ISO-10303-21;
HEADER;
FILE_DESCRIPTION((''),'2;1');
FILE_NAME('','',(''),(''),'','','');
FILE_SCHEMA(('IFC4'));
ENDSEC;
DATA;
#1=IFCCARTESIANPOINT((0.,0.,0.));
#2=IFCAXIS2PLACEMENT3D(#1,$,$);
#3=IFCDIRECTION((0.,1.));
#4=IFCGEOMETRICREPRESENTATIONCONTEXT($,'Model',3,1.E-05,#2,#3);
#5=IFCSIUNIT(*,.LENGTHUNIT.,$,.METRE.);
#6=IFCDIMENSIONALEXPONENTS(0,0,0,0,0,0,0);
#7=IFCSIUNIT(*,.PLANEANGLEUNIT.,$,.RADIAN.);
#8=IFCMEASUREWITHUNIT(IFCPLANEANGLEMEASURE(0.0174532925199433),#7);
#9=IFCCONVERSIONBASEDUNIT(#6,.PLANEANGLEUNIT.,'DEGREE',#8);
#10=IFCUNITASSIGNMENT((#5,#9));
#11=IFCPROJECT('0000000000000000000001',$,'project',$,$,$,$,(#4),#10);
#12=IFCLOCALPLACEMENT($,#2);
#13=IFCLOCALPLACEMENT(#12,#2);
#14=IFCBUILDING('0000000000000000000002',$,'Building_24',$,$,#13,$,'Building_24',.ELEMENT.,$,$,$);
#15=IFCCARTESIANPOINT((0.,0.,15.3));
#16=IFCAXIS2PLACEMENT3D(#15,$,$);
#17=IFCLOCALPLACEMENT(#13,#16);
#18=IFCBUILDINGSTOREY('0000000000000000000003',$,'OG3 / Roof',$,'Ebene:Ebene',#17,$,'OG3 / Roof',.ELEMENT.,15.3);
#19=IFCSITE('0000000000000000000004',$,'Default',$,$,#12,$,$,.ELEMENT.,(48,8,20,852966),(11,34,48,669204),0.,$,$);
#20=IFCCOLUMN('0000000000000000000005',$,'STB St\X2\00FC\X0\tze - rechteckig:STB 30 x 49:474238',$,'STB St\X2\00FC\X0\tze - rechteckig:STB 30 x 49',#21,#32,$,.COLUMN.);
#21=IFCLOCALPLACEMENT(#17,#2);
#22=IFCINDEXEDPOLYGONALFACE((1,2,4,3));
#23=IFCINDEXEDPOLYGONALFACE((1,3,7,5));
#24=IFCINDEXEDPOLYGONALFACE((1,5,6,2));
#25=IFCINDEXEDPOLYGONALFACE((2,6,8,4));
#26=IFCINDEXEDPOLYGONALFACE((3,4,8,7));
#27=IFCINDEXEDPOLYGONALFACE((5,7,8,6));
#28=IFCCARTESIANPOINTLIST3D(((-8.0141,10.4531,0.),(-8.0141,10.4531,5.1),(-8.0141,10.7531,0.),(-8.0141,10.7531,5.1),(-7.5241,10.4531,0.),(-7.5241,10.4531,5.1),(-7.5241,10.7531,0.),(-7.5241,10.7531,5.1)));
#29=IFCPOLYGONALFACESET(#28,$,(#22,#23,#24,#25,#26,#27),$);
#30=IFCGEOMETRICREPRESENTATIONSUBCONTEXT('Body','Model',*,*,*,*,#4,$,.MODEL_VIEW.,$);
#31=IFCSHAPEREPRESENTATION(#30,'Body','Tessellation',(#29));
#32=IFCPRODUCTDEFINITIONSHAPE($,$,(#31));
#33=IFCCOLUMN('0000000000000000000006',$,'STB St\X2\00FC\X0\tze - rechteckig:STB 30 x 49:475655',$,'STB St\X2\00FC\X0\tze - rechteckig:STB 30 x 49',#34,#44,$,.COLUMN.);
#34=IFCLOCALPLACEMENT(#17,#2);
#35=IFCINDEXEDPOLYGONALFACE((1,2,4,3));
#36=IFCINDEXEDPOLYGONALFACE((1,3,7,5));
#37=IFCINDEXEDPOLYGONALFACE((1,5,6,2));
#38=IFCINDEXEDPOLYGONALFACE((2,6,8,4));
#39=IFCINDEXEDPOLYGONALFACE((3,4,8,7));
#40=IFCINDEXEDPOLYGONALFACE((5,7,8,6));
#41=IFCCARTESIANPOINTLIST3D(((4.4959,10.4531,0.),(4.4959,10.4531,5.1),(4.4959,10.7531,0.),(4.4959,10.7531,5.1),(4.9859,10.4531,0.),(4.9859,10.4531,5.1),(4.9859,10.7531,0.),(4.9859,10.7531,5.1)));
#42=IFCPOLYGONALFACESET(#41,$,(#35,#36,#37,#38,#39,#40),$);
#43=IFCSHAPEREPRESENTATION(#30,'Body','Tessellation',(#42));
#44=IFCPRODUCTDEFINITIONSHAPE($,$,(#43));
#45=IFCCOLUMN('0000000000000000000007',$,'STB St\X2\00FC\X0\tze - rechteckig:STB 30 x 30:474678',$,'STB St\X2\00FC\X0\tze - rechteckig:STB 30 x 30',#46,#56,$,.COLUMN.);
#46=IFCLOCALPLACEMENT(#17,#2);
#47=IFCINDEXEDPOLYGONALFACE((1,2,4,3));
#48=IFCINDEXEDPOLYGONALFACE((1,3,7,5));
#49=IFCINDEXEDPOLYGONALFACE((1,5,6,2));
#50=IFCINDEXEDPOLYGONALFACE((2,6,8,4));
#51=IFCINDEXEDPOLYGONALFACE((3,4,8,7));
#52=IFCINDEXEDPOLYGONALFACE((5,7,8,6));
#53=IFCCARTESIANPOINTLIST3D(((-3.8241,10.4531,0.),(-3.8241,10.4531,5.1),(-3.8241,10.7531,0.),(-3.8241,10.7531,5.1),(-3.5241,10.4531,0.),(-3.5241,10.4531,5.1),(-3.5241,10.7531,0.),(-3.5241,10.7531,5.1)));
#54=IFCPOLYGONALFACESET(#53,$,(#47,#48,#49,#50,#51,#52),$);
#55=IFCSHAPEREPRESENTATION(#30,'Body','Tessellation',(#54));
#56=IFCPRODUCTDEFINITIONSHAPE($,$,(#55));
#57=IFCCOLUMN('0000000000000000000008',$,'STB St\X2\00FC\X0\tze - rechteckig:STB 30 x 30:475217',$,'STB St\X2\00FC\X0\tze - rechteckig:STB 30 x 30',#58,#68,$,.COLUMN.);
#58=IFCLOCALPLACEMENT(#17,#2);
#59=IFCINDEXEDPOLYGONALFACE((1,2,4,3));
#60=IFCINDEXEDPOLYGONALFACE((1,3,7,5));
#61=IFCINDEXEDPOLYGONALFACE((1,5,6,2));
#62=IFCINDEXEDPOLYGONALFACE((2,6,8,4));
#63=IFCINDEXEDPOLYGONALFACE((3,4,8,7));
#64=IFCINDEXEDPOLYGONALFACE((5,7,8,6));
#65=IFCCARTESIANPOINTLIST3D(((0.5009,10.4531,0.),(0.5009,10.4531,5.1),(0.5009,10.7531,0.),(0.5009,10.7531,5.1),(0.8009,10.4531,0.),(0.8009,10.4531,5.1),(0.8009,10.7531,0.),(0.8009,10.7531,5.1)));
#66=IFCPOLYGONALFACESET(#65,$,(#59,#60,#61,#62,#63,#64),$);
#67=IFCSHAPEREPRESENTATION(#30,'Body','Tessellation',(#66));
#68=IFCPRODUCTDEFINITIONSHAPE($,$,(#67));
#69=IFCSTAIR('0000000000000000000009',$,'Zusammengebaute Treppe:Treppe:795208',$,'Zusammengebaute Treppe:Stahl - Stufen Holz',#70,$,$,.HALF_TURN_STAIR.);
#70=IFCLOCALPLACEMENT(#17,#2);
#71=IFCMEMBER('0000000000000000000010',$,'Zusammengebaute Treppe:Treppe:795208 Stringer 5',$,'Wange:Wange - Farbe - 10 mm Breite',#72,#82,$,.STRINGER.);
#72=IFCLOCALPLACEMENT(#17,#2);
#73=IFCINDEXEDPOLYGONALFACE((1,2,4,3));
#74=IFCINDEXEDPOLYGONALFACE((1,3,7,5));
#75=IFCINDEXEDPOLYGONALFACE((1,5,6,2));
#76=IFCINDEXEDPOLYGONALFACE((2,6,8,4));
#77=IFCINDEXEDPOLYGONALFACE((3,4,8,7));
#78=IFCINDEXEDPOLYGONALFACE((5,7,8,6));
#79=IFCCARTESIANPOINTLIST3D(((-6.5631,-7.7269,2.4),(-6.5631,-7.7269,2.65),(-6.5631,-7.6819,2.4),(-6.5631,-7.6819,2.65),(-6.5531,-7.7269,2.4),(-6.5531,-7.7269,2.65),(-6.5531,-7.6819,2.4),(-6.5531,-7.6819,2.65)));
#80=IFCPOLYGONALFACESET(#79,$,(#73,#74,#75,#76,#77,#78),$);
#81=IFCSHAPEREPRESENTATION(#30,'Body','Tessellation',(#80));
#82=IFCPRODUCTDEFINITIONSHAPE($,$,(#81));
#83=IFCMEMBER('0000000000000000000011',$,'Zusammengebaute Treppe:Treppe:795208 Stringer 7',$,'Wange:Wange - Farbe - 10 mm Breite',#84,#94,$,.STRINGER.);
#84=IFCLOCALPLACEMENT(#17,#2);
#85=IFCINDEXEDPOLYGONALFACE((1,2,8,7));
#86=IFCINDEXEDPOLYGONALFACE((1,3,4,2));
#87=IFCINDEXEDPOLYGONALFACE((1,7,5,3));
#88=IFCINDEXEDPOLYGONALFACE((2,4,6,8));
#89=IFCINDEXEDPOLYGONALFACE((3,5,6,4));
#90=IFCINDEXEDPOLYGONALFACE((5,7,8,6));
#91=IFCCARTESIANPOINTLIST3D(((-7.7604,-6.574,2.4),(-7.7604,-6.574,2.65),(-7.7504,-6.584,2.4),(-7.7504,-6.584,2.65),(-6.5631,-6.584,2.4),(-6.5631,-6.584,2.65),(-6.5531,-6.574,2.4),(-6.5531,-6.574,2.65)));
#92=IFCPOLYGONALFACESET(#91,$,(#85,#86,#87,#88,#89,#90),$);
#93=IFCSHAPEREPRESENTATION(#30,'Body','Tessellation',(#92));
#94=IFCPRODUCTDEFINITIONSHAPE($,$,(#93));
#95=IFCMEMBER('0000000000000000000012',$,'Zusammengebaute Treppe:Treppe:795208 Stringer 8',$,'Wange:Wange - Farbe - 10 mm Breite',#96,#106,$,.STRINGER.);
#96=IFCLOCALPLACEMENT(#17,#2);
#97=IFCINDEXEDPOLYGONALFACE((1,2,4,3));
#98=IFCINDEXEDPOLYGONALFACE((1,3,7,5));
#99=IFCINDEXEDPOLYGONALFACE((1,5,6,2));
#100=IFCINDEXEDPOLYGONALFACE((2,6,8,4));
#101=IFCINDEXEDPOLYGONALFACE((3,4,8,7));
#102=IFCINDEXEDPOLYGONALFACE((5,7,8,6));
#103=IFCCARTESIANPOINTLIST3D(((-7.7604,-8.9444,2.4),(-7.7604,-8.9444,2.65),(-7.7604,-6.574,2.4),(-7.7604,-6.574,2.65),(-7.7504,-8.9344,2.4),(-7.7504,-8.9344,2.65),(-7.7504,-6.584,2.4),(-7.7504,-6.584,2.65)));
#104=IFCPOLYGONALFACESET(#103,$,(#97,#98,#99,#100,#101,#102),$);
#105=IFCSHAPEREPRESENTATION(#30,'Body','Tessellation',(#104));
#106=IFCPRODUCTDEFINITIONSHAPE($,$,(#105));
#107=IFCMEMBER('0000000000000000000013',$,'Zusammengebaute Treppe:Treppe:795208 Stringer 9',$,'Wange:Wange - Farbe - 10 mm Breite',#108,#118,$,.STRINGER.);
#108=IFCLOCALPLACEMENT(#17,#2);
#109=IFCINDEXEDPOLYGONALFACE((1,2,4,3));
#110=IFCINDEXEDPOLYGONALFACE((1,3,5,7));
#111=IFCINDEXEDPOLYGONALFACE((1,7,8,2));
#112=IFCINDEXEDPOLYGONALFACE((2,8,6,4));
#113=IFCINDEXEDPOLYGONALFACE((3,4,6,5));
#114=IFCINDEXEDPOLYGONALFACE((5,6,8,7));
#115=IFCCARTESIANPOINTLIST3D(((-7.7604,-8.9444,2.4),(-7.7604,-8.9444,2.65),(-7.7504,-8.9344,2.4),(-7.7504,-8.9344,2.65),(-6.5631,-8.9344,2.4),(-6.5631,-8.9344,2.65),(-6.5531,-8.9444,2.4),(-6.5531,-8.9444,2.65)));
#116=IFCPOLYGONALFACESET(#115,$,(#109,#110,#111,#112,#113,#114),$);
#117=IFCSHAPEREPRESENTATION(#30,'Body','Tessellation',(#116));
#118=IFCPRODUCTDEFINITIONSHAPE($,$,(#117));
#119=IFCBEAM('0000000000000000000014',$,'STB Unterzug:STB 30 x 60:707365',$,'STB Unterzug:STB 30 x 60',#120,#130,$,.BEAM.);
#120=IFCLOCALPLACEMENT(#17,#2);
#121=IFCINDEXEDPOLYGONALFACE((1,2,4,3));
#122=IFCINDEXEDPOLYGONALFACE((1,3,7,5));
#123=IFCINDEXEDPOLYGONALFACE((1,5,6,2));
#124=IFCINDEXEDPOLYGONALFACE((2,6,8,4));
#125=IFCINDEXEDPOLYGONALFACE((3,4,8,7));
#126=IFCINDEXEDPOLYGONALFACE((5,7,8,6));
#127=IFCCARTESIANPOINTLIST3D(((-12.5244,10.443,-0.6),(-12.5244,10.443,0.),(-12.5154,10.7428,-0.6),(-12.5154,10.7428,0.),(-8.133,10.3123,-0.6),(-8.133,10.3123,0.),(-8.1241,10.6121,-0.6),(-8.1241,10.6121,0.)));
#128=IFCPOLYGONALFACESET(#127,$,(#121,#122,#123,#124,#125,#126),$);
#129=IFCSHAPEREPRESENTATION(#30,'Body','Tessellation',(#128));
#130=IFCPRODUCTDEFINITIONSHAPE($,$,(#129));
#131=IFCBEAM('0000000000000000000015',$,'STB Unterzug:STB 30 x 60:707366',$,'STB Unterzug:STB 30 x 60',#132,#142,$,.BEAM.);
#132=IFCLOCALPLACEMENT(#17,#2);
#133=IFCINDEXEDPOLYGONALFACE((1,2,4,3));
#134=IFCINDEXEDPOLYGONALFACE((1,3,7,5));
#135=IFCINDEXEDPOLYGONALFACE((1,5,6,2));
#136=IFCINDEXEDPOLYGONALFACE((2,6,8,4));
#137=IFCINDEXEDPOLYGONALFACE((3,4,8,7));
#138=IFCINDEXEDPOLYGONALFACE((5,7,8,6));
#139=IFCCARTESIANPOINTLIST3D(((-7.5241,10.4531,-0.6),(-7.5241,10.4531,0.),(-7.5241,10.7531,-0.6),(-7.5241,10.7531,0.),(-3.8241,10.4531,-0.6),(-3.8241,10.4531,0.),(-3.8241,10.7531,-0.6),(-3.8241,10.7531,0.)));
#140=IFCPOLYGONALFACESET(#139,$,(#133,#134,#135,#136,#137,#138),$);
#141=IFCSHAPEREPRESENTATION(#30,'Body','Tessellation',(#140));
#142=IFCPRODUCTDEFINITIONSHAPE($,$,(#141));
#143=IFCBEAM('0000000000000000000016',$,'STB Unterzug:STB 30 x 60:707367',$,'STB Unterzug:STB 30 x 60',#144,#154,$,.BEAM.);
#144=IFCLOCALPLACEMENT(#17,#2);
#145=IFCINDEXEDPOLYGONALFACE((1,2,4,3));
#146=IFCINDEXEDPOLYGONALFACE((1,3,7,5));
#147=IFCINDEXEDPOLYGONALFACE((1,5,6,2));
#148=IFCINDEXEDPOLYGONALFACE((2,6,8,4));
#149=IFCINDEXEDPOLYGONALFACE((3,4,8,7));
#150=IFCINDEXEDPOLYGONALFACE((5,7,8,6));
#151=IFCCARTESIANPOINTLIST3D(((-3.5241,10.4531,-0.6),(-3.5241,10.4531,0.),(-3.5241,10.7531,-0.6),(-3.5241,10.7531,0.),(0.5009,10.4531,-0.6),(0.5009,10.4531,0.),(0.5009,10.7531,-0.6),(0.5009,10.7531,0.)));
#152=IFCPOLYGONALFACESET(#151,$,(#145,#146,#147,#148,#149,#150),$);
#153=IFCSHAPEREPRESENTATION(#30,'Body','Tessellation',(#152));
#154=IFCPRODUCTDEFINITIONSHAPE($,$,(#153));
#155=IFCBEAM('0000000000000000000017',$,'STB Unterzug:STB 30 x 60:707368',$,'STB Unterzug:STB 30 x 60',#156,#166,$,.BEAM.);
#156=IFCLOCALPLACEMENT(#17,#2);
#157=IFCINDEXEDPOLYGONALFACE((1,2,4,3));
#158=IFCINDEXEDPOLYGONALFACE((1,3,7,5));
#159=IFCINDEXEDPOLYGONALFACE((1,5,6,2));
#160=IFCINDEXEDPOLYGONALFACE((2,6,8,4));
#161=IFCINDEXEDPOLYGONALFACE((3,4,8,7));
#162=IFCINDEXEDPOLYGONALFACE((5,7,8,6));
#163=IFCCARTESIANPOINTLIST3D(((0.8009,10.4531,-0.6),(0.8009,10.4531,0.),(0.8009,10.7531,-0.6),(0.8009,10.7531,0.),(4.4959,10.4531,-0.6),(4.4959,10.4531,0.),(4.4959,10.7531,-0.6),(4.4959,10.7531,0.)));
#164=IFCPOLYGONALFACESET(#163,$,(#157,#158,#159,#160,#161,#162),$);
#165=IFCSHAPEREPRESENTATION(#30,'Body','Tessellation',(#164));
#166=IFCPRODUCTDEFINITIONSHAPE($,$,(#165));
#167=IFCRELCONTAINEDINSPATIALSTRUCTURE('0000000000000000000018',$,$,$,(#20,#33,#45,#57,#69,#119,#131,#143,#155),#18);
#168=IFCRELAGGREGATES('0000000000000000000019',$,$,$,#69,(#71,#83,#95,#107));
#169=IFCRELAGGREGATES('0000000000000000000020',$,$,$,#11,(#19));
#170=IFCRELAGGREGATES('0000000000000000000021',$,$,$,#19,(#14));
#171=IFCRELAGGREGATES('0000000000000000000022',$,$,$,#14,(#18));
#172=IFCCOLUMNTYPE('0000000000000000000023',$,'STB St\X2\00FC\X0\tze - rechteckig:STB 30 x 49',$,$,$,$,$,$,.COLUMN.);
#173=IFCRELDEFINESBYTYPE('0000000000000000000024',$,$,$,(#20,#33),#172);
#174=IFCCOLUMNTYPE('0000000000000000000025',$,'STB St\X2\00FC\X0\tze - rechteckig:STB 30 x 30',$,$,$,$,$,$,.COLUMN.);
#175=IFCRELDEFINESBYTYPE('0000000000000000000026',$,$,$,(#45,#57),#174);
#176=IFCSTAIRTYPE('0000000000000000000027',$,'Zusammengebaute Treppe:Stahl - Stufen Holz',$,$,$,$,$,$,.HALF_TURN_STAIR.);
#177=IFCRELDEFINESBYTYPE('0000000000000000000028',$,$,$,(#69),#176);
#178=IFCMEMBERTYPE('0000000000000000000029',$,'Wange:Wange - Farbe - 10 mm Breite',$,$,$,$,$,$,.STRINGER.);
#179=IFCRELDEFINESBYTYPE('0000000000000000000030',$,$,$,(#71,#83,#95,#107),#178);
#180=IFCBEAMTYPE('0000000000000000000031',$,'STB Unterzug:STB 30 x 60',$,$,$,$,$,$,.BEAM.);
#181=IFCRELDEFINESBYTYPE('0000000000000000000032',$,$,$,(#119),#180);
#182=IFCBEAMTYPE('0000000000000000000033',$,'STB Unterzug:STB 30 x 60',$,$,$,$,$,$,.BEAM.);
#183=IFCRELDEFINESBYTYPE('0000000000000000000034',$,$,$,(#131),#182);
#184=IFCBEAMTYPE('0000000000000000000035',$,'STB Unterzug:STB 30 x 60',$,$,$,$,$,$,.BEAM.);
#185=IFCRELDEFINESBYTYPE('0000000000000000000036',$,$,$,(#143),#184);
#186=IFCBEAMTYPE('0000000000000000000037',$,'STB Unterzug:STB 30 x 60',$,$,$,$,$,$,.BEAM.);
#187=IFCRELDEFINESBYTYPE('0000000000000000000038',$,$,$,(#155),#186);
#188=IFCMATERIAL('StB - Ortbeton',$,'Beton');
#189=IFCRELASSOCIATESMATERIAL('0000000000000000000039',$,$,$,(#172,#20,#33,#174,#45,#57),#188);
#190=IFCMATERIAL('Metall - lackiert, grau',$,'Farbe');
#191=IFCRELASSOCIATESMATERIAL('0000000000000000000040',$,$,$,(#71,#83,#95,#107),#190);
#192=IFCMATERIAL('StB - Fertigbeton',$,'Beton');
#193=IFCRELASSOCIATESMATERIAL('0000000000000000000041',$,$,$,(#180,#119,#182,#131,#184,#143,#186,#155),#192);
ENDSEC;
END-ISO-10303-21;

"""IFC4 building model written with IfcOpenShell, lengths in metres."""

from ifc_helpers import new_model, entity, si_unit, converted_unit, direction, frame, origin, place, context, subcontext, project, spatial, indexed_curve, outline, extrude, source, transform, mapped, material, type_object, type_shapes, element, aggregate, save


model = new_model("IFC4")

# Units and contexts
model_context = context("Model", 3, precision=1e-05, world=origin(), true_north=direction((0.0, 1.0)))
body_context = subcontext(model_context, "Body", "Model", "MODEL_VIEW")
ifc_project = project(units=[si_unit("LENGTHUNIT", "METRE"), converted_unit("PLANEANGLEUNIT", "DEGREE", entity("IfcPlaneAngleMeasure", 0.0174532925199433), si_unit("PLANEANGLEUNIT", "RADIAN"), dimensions=[0, 0, 0, 0, 0, 0, 0])], contexts=[model_context])

# Site, building, storey
site_placement = place(None, origin())
site = spatial("IfcSite", under=ifc_project, at=site_placement, Name="Default", CompositionType="ELEMENT", RefLatitude=(48, 8, 20, 852966), RefLongitude=(11, 34, 48, 669204), RefElevation=0.0)
building_placement = place(site_placement, origin())
building = spatial("IfcBuilding", under=site, at=building_placement, Name="Building_24", LongName="Building_24", CompositionType="ELEMENT")
storey_placement = place(building_placement, frame((0.0, 0.0, 15.3)))
storey = spatial("IfcBuildingStorey", under=building, at=storey_placement, Name="OG3 / Roof", ObjectType="Ebene:Ebene", LongName="OG3 / Roof", CompositionType="ELEMENT", Elevation=15.3)

# Columns
ifc_material_1 = material(Name="StB - Ortbeton", Category="Beton")
column_type_1 = type_object("IfcColumnType", Name="STB Stütze - rechteckig:STB 30 x 49", PredefinedType="COLUMN", material=ifc_material_1)
shared_shape_1 = source(origin(), body_context, "Body", "SweptSolid", [
    extrude(outline(indexed_curve([(-0.245, -0.15), (0.245, -0.15), (0.245, 0.15), (-0.245, 0.15), (-0.245, -0.15)], self_intersect=False)), frame((0.0, 0.0, 15.3), z_axis=(0.0, 0.0, 1.0), x_axis=(-1.0, 0.0, 0.0)), (0.0, 0.0, 1.0), 5.1),
])
type_shapes(column_type_1, [shared_shape_1])
for number, where, name in (
    (1, (-7.7691, 10.6031, -15.3), "STB Stütze - rechteckig:STB 30 x 49:474238"),
    (2, (4.7409, 10.6031, -15.3), "STB Stütze - rechteckig:STB 30 x 49:475655"),
):
    element("IfcColumn", number, at=place(storey_placement, frame(where)), inside=storey, type_object=column_type_1, material=ifc_material_1, Name=name, ObjectType="STB Stütze - rechteckig:STB 30 x 49", PredefinedType="COLUMN", context=body_context, shape_type="MappedRepresentation", body=[
        mapped(shared_shape_1, transform((0.0, 0.0, 0.0), scale=1.0)),
    ])
column_type_2 = type_object("IfcColumnType", Name="STB Stütze - rechteckig:STB 30 x 30", PredefinedType="COLUMN", material=ifc_material_1)
shared_shape_2 = source(origin(), body_context, "Body", "SweptSolid", [
    extrude(outline(indexed_curve([(-0.15, -0.15), (0.15, -0.15), (0.15, 0.15), (-0.15, 0.15), (-0.15, -0.15)], self_intersect=False)), frame((0.0, 0.0, 15.3), z_axis=(0.0, 0.0, 1.0), x_axis=(-1.0, 0.0, 0.0)), (0.0, 0.0, 1.0), 5.1),
])
type_shapes(column_type_2, [shared_shape_2])
for number, where, name in (
    (3, (-3.6741, 10.6031, -15.3), "STB Stütze - rechteckig:STB 30 x 30:474678"),
    (4, (0.6509, 10.6031, -15.3), "STB Stütze - rechteckig:STB 30 x 30:475217"),
):
    element("IfcColumn", number, at=place(storey_placement, frame(where)), inside=storey, type_object=column_type_2, material=ifc_material_1, Name=name, ObjectType="STB Stütze - rechteckig:STB 30 x 30", PredefinedType="COLUMN", context=body_context, shape_type="MappedRepresentation", body=[
        mapped(shared_shape_2, transform((0.0, 0.0, 0.0), scale=1.0)),
    ])

# Stair, members
stair_type = type_object("IfcStairType", Name="Zusammengebaute Treppe:Stahl - Stufen Holz", PredefinedType="HALF_TURN_STAIR")
stair_placement = place(storey_placement, origin())
stair = element("IfcStair", 5, at=stair_placement, inside=storey, type_object=stair_type, Name="Zusammengebaute Treppe:Treppe:795208", ObjectType="Zusammengebaute Treppe:Stahl - Stufen Holz", PredefinedType="HALF_TURN_STAIR")
ifc_material_2 = material(Name="Metall - lackiert, grau", Category="Farbe")
member_type = type_object("IfcMemberType", Name="Wange:Wange - Farbe - 10 mm Breite", PredefinedType="STRINGER")
member_1_placement = place(stair_placement, origin())
member_1 = element("IfcMember", 6, at=member_1_placement, type_object=member_type, material=ifc_material_2, Name="Zusammengebaute Treppe:Treppe:795208 Stringer 5", ObjectType="Wange:Wange - Farbe - 10 mm Breite", PredefinedType="STRINGER", context=body_context, shape_type="SweptSolid", body=[
    extrude(outline(indexed_curve([(-0.0225, -0.005), (0.0225, -0.005), (0.0225, 0.005), (-0.0225, 0.005), (-0.0225, -0.005)], self_intersect=False)), frame((-6.5581, -7.7044, 2.4), z_axis=(0.0, 0.0, 1.0), x_axis=(0.0, 1.0, 0.0)), (0.0, 0.0, 1.0), 0.25),
])
member_2_placement = place(stair_placement, origin())
member_2 = element("IfcMember", 7, at=member_2_placement, type_object=member_type, material=ifc_material_2, Name="Zusammengebaute Treppe:Treppe:795208 Stringer 7", ObjectType="Wange:Wange - Farbe - 10 mm Breite", PredefinedType="STRINGER", context=body_context, shape_type="SweptSolid", body=[
    extrude(outline(indexed_curve([(-0.6037, -0.005), (0.6037, -0.005), (0.5937, 0.005), (-0.5937, 0.005), (-0.6037, -0.005)], self_intersect=False)), frame((-7.1568, -6.579, 2.4), z_axis=(0.0, 0.0, 1.0), x_axis=(-1.0, 0.0, 0.0)), (0.0, 0.0, 1.0), 0.25),
])
member_3_placement = place(stair_placement, origin())
member_3 = element("IfcMember", 8, at=member_3_placement, type_object=member_type, material=ifc_material_2, Name="Zusammengebaute Treppe:Treppe:795208 Stringer 8", ObjectType="Wange:Wange - Farbe - 10 mm Breite", PredefinedType="STRINGER", context=body_context, shape_type="SweptSolid", body=[
    extrude(outline(indexed_curve([(-1.1852, -0.005), (1.1852, -0.005), (1.1752, 0.005), (-1.1752, 0.005), (-1.1852, -0.005)], self_intersect=False)), frame((-7.7554, -7.7592, 2.4), z_axis=(0.0, 0.0, 1.0), x_axis=(0.0, -1.0, 0.0)), (0.0, 0.0, 1.0), 0.25),
])
member_4_placement = place(stair_placement, origin())
member_4 = element("IfcMember", 9, at=member_4_placement, type_object=member_type, material=ifc_material_2, Name="Zusammengebaute Treppe:Treppe:795208 Stringer 9", ObjectType="Wange:Wange - Farbe - 10 mm Breite", PredefinedType="STRINGER", context=body_context, shape_type="SweptSolid", body=[
    extrude(outline(indexed_curve([(-0.6037, -0.005), (0.6037, -0.005), (0.5937, 0.005), (-0.5937, 0.005), (-0.6037, -0.005)], self_intersect=False)), frame((-7.1568, -8.9394, 2.4)), (0.0, 0.0, 1.0), 0.25),
])
aggregate(stair, [member_1, member_2, member_3, member_4])

# Beams
ifc_material_3 = material(Name="StB - Fertigbeton", Category="Beton")
beam_type_1 = type_object("IfcBeamType", Name="STB Unterzug:STB 30 x 60", PredefinedType="BEAM", material=ifc_material_3)
shared_shape_3 = source(origin(), body_context, "Body", "SweptSolid", [
    extrude(outline(indexed_curve([(-2.1967, -0.15), (2.1967, -0.15), (2.1967, 0.15), (-2.1967, 0.15), (-2.1967, -0.15)], self_intersect=False)), frame((-0.0077, 0.0, -0.3), z_axis=(0.0, 0.0, 1.0), x_axis=(-1.0, 0.0, 0.0)), (0.0, 0.0, 1.0), 0.6),
])
type_shapes(beam_type_1, [shared_shape_3])
beam_1_placement = place(storey_placement, frame((-10.3166, 10.5273, -0.3), z_axis=(0.0, 0.0, 1.0), x_axis=(0.999557, -0.029749, 0.0)))
element("IfcBeam", 10, at=beam_1_placement, inside=storey, type_object=beam_type_1, material=ifc_material_3, Name="STB Unterzug:STB 30 x 60:707365", ObjectType="STB Unterzug:STB 30 x 60", PredefinedType="BEAM", context=body_context, shape_type="MappedRepresentation", body=[
    mapped(shared_shape_3, transform((0.0, 0.0, 0.0), scale=1.0)),
])
beam_type_2 = type_object("IfcBeamType", Name="STB Unterzug:STB 30 x 60", PredefinedType="BEAM", material=ifc_material_3)
shared_shape_4 = source(origin(), body_context, "Body", "SweptSolid", [
    extrude(outline(indexed_curve([(-1.85, -0.15), (1.85, -0.15), (1.85, 0.15), (-1.85, 0.15), (-1.85, -0.15)], self_intersect=False)), frame((0.0308, 0.0, -0.3), z_axis=(0.0, 0.0, 1.0), x_axis=(-1.0, 0.0, 0.0)), (0.0, 0.0, 1.0), 0.6),
])
type_shapes(beam_type_2, [shared_shape_4])
beam_2_placement = place(storey_placement, frame((-5.7049, 10.6031, -0.3)))
element("IfcBeam", 11, at=beam_2_placement, inside=storey, type_object=beam_type_2, material=ifc_material_3, Name="STB Unterzug:STB 30 x 60:707366", ObjectType="STB Unterzug:STB 30 x 60", PredefinedType="BEAM", context=body_context, shape_type="MappedRepresentation", body=[
    mapped(shared_shape_4, transform((0.0, 0.0, 0.0), scale=1.0)),
])
beam_type_3 = type_object("IfcBeamType", Name="STB Unterzug:STB 30 x 60", PredefinedType="BEAM", material=ifc_material_3)
shared_shape_5 = source(origin(), body_context, "Body", "SweptSolid", [
    extrude(outline(indexed_curve([(-2.0125, -0.15), (2.0125, -0.15), (2.0125, 0.15), (-2.0125, 0.15), (-2.0125, -0.15)], self_intersect=False)), frame((-0.0275, 0.0, -0.3), z_axis=(0.0, 0.0, 1.0), x_axis=(-1.0, 0.0, 0.0)), (0.0, 0.0, 1.0), 0.6),
])
type_shapes(beam_type_3, [shared_shape_5])
beam_3_placement = place(storey_placement, frame((-1.4841, 10.6031, -0.3)))
element("IfcBeam", 12, at=beam_3_placement, inside=storey, type_object=beam_type_3, material=ifc_material_3, Name="STB Unterzug:STB 30 x 60:707367", ObjectType="STB Unterzug:STB 30 x 60", PredefinedType="BEAM", context=body_context, shape_type="MappedRepresentation", body=[
    mapped(shared_shape_5, transform((0.0, 0.0, 0.0), scale=1.0)),
])
beam_type_4 = type_object("IfcBeamType", Name="STB Unterzug:STB 30 x 60", PredefinedType="BEAM", material=ifc_material_3)
shared_shape_6 = source(origin(), body_context, "Body", "SweptSolid", [
    extrude(outline(indexed_curve([(-1.8475, -0.15), (1.8475, -0.15), (1.8475, 0.15), (-1.8475, 0.15), (-1.8475, -0.15)], self_intersect=False)), frame((-0.1808, 0.0, -0.3), z_axis=(0.0, 0.0, 1.0), x_axis=(-1.0, 0.0, 0.0)), (0.0, 0.0, 1.0), 0.6),
])
type_shapes(beam_type_4, [shared_shape_6])
beam_4_placement = place(storey_placement, frame((2.8293, 10.6031, -0.3)))
element("IfcBeam", 13, at=beam_4_placement, inside=storey, type_object=beam_type_4, material=ifc_material_3, Name="STB Unterzug:STB 30 x 60:707368", ObjectType="STB Unterzug:STB 30 x 60", PredefinedType="BEAM", context=body_context, shape_type="MappedRepresentation", body=[
    mapped(shared_shape_6, transform((0.0, 0.0, 0.0), scale=1.0)),
])

save(model, "model.ifc")
